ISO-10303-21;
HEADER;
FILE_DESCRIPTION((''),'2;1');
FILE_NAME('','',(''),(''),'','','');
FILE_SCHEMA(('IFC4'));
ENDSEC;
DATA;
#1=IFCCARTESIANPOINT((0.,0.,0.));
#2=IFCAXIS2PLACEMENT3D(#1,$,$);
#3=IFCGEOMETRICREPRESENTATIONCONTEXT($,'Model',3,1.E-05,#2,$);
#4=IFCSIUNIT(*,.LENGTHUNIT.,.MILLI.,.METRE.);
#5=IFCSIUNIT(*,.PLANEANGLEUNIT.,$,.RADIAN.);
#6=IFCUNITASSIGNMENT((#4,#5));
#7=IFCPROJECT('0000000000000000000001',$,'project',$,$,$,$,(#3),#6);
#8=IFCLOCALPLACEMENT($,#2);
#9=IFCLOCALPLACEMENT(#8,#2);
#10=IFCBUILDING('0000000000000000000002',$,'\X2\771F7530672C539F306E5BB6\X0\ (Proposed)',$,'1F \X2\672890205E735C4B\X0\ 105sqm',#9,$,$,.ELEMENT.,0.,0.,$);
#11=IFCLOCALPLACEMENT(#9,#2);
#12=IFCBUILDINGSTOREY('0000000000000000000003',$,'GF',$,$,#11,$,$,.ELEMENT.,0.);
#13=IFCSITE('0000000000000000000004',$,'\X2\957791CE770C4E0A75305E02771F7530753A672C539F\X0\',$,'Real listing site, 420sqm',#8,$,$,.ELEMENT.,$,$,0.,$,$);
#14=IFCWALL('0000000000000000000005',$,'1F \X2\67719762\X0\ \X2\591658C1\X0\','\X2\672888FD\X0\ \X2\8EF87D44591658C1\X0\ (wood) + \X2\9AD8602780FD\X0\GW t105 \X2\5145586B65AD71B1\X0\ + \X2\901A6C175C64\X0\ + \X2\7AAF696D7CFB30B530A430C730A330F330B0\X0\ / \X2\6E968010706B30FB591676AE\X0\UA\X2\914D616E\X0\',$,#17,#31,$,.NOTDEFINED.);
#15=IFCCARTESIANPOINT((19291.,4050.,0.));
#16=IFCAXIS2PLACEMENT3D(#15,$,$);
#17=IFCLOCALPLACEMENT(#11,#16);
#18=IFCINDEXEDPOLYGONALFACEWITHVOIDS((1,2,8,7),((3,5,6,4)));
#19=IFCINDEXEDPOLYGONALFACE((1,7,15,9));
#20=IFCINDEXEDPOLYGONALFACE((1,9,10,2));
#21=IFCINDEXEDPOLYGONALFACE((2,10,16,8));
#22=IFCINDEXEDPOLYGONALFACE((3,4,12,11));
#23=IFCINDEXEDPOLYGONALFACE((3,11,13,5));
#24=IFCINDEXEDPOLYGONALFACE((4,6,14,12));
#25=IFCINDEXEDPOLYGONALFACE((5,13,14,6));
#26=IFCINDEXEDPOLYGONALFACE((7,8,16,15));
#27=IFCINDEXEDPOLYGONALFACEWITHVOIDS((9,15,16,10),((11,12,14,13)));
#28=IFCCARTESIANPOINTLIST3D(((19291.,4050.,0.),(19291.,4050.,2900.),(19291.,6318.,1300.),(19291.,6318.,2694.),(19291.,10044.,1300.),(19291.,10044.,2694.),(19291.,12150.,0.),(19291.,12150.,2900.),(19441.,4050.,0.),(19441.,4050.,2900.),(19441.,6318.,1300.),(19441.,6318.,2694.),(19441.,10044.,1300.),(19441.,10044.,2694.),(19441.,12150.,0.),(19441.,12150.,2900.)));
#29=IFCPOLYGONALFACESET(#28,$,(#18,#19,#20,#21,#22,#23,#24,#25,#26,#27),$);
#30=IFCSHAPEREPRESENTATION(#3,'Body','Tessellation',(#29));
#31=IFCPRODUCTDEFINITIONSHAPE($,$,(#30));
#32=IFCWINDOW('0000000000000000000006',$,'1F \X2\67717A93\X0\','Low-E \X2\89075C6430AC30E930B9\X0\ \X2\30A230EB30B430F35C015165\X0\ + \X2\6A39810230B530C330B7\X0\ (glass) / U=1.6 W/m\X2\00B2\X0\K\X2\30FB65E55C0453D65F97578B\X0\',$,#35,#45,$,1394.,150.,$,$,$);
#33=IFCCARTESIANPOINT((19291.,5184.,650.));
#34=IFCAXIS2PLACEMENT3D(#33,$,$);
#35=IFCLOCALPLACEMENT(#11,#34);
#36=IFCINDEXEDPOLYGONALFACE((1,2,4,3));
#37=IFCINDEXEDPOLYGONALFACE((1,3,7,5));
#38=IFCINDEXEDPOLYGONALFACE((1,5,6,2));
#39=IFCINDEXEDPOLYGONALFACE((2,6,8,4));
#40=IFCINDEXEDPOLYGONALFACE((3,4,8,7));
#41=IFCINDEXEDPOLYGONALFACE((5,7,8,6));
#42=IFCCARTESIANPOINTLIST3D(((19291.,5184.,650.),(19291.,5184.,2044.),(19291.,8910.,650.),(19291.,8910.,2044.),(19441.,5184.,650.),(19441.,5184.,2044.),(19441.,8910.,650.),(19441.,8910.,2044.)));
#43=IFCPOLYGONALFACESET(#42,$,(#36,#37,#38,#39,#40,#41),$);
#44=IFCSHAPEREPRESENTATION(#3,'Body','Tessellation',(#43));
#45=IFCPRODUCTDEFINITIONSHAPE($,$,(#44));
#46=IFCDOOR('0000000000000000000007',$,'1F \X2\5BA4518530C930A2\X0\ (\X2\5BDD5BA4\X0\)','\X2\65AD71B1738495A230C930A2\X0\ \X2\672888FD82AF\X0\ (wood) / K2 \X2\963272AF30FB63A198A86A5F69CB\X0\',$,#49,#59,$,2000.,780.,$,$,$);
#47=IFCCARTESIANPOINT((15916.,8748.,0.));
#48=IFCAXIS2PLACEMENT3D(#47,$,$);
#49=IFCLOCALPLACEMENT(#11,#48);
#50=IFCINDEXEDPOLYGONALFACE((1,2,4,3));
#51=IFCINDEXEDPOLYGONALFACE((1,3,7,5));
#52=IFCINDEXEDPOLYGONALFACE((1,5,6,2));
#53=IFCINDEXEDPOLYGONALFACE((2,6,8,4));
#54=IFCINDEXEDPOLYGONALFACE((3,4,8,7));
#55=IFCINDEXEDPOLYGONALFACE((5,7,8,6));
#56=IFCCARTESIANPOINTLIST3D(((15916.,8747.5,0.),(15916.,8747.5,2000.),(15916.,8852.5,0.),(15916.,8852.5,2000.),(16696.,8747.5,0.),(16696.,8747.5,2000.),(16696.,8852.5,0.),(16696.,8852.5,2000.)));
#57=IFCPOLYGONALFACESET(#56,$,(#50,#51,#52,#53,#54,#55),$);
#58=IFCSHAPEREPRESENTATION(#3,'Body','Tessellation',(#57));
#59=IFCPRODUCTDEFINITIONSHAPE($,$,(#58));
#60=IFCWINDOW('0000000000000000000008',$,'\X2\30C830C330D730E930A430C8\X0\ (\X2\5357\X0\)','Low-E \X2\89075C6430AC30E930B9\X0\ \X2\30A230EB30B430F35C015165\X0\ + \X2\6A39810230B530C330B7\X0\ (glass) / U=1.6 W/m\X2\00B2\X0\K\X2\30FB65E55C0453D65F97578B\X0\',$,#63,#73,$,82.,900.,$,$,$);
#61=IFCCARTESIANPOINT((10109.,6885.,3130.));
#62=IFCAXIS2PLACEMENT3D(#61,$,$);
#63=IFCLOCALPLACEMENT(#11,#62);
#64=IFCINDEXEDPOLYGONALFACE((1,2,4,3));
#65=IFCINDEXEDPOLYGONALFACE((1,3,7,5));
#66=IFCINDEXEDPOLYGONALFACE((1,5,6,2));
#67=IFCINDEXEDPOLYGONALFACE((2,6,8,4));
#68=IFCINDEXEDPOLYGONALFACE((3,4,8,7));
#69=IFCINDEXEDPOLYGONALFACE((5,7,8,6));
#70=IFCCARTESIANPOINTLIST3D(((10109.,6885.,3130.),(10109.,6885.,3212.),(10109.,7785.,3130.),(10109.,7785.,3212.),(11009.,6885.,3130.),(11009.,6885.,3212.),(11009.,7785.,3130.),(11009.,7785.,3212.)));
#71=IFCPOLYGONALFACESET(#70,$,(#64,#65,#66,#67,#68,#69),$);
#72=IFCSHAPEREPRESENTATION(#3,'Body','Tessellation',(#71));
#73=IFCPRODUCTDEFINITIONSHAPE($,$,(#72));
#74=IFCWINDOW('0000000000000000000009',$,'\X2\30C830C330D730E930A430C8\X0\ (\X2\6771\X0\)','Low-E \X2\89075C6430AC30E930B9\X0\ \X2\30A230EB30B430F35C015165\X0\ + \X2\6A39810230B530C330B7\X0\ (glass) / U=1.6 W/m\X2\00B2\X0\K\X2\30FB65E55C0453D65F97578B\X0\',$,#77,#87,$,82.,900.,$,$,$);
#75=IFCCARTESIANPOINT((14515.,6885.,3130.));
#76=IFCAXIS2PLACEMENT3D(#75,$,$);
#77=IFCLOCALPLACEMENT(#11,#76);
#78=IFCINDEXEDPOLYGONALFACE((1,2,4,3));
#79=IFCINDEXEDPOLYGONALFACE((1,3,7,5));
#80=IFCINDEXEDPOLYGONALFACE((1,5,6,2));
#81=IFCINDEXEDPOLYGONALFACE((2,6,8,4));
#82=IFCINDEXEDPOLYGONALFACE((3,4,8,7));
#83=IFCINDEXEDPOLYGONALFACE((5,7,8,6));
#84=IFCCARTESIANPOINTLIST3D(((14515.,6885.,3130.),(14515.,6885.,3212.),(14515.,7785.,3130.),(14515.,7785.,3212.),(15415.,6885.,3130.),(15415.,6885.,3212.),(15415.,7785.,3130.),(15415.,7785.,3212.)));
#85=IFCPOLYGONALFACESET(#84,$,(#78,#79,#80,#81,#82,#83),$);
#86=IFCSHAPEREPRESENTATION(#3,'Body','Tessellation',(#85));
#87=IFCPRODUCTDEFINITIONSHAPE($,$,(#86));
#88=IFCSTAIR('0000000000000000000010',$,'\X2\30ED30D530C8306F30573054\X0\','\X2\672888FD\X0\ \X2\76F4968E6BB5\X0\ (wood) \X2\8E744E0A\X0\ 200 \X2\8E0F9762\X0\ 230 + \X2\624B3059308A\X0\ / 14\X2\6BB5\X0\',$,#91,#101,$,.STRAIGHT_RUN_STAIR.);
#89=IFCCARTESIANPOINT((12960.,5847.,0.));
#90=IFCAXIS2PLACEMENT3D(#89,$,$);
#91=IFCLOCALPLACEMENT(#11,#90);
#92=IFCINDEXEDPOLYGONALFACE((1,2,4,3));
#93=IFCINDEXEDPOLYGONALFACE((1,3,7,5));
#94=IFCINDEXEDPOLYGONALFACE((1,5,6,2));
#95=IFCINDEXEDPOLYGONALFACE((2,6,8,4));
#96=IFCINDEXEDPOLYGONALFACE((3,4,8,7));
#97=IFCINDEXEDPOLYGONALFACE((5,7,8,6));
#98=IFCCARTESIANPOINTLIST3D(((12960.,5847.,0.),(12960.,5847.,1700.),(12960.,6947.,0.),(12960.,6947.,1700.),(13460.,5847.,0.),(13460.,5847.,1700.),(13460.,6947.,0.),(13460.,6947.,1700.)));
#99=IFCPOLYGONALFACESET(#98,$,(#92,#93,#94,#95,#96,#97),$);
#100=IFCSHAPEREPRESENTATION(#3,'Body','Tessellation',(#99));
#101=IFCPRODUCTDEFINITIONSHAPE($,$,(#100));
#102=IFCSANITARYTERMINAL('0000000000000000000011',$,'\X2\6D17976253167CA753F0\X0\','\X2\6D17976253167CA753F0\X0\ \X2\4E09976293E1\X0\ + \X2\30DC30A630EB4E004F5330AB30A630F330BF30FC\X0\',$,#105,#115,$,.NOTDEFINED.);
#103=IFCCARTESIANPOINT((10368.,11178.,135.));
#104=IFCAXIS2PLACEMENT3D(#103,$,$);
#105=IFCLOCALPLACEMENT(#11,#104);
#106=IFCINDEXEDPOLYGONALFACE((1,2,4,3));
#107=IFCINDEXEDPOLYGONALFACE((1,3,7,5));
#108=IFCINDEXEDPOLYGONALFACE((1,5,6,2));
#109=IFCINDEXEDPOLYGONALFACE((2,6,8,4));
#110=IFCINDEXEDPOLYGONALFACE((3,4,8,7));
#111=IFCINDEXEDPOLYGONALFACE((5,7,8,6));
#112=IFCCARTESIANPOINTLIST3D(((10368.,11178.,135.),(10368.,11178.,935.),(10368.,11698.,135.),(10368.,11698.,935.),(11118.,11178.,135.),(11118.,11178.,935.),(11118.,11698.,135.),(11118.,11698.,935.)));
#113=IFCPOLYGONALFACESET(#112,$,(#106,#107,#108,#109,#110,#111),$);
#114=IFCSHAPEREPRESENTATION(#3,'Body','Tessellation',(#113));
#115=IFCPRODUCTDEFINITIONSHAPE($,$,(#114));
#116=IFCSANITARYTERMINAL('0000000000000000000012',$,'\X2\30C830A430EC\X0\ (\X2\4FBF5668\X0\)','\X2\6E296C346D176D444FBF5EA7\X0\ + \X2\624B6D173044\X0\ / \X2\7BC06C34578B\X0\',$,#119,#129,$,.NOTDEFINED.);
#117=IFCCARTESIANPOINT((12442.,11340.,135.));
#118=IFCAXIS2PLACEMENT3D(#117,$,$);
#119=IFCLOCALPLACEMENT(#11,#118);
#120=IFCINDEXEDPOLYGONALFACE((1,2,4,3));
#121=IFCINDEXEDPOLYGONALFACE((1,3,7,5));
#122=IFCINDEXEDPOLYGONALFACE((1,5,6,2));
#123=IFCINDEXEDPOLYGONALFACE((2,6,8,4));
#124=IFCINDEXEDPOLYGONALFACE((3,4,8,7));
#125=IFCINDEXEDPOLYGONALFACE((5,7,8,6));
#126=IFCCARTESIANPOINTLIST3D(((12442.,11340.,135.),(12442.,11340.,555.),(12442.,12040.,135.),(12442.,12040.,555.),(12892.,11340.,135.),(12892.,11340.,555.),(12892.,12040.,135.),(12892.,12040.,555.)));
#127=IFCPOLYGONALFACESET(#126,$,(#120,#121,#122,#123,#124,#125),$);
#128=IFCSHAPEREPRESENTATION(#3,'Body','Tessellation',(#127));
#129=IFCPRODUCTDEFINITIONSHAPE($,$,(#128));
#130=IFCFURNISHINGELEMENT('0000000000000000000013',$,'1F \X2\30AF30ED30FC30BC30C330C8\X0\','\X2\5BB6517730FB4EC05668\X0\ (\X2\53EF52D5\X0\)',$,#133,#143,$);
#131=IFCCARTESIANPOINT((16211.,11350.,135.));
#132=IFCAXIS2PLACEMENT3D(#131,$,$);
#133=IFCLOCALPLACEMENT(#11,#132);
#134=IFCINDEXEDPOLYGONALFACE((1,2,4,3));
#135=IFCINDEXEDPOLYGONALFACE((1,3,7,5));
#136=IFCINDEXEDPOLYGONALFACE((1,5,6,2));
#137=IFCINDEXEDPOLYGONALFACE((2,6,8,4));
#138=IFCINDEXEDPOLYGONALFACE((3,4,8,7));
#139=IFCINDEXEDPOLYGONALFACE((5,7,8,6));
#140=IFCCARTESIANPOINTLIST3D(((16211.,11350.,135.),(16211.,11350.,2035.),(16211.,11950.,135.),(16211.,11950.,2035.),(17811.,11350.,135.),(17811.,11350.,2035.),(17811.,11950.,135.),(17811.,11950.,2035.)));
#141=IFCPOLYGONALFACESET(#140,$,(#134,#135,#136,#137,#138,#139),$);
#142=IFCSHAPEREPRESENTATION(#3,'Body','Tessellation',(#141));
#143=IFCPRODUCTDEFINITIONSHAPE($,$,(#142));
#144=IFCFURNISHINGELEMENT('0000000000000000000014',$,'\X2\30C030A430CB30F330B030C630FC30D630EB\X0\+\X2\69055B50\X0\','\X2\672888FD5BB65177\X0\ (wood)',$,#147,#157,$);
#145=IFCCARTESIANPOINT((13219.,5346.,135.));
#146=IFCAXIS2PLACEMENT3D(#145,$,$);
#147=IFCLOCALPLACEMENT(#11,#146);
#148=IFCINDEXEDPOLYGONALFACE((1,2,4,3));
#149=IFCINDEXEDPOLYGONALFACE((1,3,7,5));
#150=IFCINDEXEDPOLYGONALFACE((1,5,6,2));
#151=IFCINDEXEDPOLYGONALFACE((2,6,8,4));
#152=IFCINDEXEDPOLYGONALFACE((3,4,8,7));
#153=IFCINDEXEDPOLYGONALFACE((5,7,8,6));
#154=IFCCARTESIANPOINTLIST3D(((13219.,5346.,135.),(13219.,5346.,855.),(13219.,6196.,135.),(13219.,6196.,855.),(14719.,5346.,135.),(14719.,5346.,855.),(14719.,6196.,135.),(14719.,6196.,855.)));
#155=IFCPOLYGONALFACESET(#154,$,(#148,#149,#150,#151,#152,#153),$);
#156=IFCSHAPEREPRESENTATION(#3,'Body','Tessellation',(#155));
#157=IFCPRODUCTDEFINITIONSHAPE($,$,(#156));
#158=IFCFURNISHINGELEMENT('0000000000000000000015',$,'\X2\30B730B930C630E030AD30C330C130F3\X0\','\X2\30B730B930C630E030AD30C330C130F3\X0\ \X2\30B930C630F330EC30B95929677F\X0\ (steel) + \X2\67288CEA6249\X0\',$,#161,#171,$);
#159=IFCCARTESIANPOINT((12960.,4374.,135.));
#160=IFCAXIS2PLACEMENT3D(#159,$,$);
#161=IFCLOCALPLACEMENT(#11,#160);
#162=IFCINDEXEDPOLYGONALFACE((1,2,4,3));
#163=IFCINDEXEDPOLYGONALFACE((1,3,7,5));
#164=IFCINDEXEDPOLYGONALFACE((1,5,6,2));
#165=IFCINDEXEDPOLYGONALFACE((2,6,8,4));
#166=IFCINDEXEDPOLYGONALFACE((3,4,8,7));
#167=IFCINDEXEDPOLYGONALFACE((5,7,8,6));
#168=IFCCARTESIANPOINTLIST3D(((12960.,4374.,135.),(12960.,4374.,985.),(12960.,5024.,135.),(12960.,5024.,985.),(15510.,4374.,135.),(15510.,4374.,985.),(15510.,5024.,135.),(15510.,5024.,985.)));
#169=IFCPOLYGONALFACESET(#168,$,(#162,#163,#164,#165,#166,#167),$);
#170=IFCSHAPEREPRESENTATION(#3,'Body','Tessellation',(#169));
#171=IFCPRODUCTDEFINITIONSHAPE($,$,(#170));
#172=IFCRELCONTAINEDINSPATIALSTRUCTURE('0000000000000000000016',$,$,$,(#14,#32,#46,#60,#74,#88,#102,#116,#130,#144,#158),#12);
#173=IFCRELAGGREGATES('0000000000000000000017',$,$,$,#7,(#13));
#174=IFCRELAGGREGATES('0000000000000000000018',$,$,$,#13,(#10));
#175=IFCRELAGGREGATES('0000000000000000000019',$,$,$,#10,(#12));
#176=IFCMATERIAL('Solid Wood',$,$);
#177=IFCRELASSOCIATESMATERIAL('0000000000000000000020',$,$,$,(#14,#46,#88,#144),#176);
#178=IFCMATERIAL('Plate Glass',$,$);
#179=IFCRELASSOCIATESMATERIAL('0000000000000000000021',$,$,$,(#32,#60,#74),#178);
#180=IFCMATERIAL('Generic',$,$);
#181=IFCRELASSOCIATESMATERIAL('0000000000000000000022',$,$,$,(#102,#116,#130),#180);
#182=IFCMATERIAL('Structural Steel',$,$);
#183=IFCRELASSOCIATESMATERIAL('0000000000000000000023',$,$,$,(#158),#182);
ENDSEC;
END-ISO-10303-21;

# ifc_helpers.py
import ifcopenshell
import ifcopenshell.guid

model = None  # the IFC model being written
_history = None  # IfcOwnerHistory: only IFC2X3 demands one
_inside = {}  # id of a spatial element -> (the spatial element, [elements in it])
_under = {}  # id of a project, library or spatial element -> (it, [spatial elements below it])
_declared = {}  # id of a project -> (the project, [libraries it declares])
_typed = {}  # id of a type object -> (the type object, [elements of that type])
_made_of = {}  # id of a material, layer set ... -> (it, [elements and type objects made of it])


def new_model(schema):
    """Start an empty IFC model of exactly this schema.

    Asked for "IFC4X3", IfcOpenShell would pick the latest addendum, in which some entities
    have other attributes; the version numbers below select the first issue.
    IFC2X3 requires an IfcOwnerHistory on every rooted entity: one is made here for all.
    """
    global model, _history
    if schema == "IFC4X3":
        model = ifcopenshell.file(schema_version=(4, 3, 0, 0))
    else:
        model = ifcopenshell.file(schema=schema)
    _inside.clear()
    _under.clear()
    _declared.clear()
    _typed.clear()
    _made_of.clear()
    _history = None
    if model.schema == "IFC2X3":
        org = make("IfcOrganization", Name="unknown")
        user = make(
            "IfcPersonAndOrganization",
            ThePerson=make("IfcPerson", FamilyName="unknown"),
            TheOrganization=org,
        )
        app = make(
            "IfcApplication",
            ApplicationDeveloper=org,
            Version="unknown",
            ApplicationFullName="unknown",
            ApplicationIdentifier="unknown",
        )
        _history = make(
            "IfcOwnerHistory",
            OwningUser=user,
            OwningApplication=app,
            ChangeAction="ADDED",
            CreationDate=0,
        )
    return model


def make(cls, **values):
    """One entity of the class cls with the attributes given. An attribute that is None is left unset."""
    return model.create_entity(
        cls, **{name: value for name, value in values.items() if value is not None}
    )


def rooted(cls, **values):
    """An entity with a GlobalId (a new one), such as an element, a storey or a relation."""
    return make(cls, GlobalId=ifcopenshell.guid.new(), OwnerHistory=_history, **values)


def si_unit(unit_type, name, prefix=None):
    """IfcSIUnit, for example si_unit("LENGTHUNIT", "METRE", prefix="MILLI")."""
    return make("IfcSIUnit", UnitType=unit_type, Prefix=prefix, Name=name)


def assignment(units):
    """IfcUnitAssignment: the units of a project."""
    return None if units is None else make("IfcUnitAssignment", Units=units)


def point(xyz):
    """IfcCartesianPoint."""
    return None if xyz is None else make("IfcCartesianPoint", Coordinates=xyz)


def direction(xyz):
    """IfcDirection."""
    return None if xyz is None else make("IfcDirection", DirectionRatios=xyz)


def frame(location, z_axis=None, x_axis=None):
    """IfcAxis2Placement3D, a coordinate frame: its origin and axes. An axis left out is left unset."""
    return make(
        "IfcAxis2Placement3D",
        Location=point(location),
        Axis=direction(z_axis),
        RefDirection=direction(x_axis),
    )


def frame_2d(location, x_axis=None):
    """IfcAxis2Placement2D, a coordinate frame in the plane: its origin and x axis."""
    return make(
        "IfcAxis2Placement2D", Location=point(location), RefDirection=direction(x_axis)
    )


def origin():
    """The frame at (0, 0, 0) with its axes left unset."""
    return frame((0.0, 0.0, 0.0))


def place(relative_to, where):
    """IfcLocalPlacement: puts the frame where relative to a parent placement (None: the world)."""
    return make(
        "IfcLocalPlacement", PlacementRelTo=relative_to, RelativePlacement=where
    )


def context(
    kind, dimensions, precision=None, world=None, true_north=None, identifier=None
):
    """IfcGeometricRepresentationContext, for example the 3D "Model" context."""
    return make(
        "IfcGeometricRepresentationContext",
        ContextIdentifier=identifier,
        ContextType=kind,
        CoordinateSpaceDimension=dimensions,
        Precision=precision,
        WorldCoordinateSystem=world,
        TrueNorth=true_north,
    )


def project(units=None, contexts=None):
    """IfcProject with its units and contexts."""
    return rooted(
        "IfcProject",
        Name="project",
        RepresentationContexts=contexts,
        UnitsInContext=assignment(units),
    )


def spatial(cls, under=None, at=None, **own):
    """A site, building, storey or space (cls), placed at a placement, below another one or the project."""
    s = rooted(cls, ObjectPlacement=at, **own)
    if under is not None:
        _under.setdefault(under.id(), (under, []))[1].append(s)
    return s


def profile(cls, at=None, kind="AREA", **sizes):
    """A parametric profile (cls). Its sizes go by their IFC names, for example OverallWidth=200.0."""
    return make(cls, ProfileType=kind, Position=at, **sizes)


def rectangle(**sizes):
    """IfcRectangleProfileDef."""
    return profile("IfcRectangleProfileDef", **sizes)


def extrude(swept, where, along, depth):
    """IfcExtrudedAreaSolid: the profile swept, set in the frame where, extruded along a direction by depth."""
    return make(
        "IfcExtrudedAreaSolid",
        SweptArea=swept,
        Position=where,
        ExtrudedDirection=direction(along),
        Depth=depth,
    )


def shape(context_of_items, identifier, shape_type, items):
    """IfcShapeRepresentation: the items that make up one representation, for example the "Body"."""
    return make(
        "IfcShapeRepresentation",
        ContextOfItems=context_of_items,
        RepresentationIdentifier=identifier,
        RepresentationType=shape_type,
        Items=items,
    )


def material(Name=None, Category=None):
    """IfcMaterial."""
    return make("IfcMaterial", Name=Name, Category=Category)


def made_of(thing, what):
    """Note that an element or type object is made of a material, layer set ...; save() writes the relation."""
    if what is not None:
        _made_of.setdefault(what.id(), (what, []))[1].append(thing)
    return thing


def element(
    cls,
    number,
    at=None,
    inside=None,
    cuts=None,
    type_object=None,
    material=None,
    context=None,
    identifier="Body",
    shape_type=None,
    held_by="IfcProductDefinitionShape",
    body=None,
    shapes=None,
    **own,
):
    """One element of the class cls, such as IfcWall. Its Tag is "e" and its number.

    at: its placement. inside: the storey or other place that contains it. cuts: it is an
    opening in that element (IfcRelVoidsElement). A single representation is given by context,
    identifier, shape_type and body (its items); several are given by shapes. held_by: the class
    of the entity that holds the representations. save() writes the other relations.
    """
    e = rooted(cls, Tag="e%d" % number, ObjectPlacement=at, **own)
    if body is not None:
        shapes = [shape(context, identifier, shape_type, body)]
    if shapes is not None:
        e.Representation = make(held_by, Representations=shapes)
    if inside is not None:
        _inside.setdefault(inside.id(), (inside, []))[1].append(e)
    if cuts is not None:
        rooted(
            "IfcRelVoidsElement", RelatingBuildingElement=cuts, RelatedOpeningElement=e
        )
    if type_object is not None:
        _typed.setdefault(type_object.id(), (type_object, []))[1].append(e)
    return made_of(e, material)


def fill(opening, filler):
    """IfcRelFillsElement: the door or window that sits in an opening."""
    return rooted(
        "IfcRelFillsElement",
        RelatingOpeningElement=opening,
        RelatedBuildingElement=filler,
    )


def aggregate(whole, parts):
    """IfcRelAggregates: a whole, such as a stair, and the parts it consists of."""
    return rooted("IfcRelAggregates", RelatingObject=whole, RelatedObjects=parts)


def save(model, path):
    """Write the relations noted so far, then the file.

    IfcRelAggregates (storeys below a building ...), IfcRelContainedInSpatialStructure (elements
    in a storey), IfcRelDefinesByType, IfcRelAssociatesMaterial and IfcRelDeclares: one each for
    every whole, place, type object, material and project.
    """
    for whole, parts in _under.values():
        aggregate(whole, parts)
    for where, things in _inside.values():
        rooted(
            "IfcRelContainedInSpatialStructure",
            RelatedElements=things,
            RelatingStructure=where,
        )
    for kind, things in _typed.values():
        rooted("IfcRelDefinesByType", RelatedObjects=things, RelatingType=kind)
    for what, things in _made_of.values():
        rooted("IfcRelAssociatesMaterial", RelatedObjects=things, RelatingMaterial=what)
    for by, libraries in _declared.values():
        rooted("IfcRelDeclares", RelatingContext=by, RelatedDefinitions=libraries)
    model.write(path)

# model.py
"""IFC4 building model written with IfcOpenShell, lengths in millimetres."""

from ifc_helpers import new_model, si_unit, frame, frame_2d, origin, place, context, project, spatial, rectangle, extrude, material, element, fill, save


model = new_model("IFC4")

# Units and contexts
model_context = context("Model", 3, precision=1e-05, world=origin())
ifc_project = project(units=[si_unit("LENGTHUNIT", "METRE", prefix="MILLI"), si_unit("PLANEANGLEUNIT", "RADIAN")], contexts=[model_context])

# Site, building, storey
site_placement = place(None, origin())
site = spatial("IfcSite", under=ifc_project, at=site_placement, Name="長野県上田市真田町本原", ObjectType="Real listing site, 420sqm", CompositionType="ELEMENT", RefElevation=0.0)
building_placement = place(site_placement, origin())
building = spatial("IfcBuilding", under=site, at=building_placement, Name="真田本原の家 (Proposed)", ObjectType="1F 木造平屋 105sqm", CompositionType="ELEMENT", ElevationOfRefHeight=0.0, ElevationOfTerrain=0.0)
storey_placement = place(building_placement, origin())
storey = spatial("IfcBuildingStorey", under=building, at=storey_placement, Name="GF", CompositionType="ELEMENT", Elevation=0.0)

# Wall, opening, window
ifc_material_1 = material(Name="Solid Wood")
wall_1_placement = place(storey_placement, frame((19291.0, 4050.0, 0.0)))
wall_1 = element("IfcWall", 1, at=wall_1_placement, inside=storey, material=ifc_material_1, Name="1F 東面 外壁", Description="木製 軸組外壁 (wood) + 高性能GW t105 充填断熱 + 通気層 + 窯業系サイディング / 準耐火・外皮UA配慮", PredefinedType="NOTDEFINED", context=model_context, shape_type="SweptSolid", body=[
    extrude(rectangle(XDim=150.0, YDim=8100.0, at=frame_2d((75.0, 4050.0))), frame((19291.0, 4050.0, 0.0)), (0.0, 0.0, 1.0), 2900.0),
])
opening_placement = place(storey_placement, frame((19291.0, 5184.0, 650.0)))
opening = element("IfcOpeningElement", 2, at=opening_placement, cuts=wall_1, PredefinedType="NOTDEFINED", context=model_context, shape_type="SweptSolid", body=[
    extrude(rectangle(XDim=150.0, YDim=3726.0, at=frame_2d((75.0, 1863.0))), frame((19291.0, 5184.0, 650.0)), (0.0, 0.0, 1.0), 1394.0),
])
ifc_material_2 = material(Name="Plate Glass")
window_1_placement = place(storey_placement, frame((19291.0, 5184.0, 650.0)))
window_1 = element("IfcWindow", 3, at=window_1_placement, inside=storey, material=ifc_material_2, Name="1F 東窓", Description="Low-E 複層ガラス アルゴン封入 + 樹脂サッシ (glass) / U=1.6 W/m²K・日射取得型", OverallHeight=1394.0, OverallWidth=150.0, context=model_context, shape_type="SweptSolid", body=[
    extrude(rectangle(XDim=150.0, YDim=3726.0, at=frame_2d((75.0, 1863.0))), frame((19291.0, 5184.0, 650.0)), (0.0, 0.0, 1.0), 1394.0),
])
fill(opening, window_1)

# Door
door_placement = place(storey_placement, frame((15916.0, 8748.0, 0.0)))
element("IfcDoor", 4, at=door_placement, inside=storey, material=ifc_material_1, Name="1F 室内ドア (寝室)", Description="断熱玄関ドア 木製芯 (wood) / K2 防犯・採風機構", OverallHeight=2000.0, OverallWidth=780.0, context=model_context, shape_type="SweptSolid", body=[
    extrude(rectangle(XDim=780.0, YDim=105.0, at=frame_2d((390.0, 52.0))), frame((15916.0, 8748.0, 0.0)), (0.0, 0.0, 1.0), 2000.0),
])

# Windows
window_2_placement = place(storey_placement, frame((10109.0, 6885.0, 3130.0)))
element("IfcWindow", 5, at=window_2_placement, inside=storey, material=ifc_material_2, Name="トップライト (南)", Description="Low-E 複層ガラス アルゴン封入 + 樹脂サッシ (glass) / U=1.6 W/m²K・日射取得型", OverallHeight=82.0, OverallWidth=900.0, context=model_context, shape_type="SweptSolid", body=[
    extrude(rectangle(XDim=900.0, YDim=900.0, at=frame_2d((450.0, 450.0))), frame((10109.0, 6885.0, 3130.0)), (0.0, 0.0, 1.0), 82.0),
])
window_3_placement = place(storey_placement, frame((14515.0, 6885.0, 3130.0)))
element("IfcWindow", 6, at=window_3_placement, inside=storey, material=ifc_material_2, Name="トップライト (東)", Description="Low-E 複層ガラス アルゴン封入 + 樹脂サッシ (glass) / U=1.6 W/m²K・日射取得型", OverallHeight=82.0, OverallWidth=900.0, context=model_context, shape_type="SweptSolid", body=[
    extrude(rectangle(XDim=900.0, YDim=900.0, at=frame_2d((450.0, 450.0))), frame((14515.0, 6885.0, 3130.0)), (0.0, 0.0, 1.0), 82.0),
])

# Stair
stair_placement = place(storey_placement, frame((12960.0, 5847.0, 0.0)))
element("IfcStair", 7, at=stair_placement, inside=storey, material=ifc_material_1, Name="ロフトはしご", Description="木製 直階段 (wood) 蹴上 200 踏面 230 + 手すり / 14段", PredefinedType="STRAIGHT_RUN_STAIR", context=model_context, shape_type="SweptSolid", body=[
    extrude(rectangle(XDim=500.0, YDim=1100.0, at=frame_2d((250.0, 550.0))), frame((12960.0, 5847.0, 0.0)), (0.0, 0.0, 1.0), 1700.0),
])

# Sanitary terminals
ifc_material_3 = material(Name="Generic")
sanitary_terminal_1_placement = place(storey_placement, frame((10368.0, 11178.0, 135.0)))
element("IfcSanitaryTerminal", 8, at=sanitary_terminal_1_placement, inside=storey, material=ifc_material_3, Name="洗面化粧台", Description="洗面化粧台 三面鏡 + ボウル一体カウンター", PredefinedType="NOTDEFINED", context=model_context, shape_type="SweptSolid", body=[
    extrude(rectangle(XDim=750.0, YDim=520.0, at=frame_2d((375.0, 260.0))), frame((10368.0, 11178.0, 135.0)), (0.0, 0.0, 1.0), 800.0),
])
sanitary_terminal_2_placement = place(storey_placement, frame((12442.0, 11340.0, 135.0)))
element("IfcSanitaryTerminal", 9, at=sanitary_terminal_2_placement, inside=storey, material=ifc_material_3, Name="トイレ (便器)", Description="温水洗浄便座 + 手洗い / 節水型", PredefinedType="NOTDEFINED", context=model_context, shape_type="SweptSolid", body=[
    extrude(rectangle(XDim=450.0, YDim=700.0, at=frame_2d((225.0, 350.0))), frame((12442.0, 11340.0, 135.0)), (0.0, 0.0, 1.0), 420.0),
])

# Furnishing elements
furnishing_1_placement = place(storey_placement, frame((16211.0, 11350.0, 135.0)))
element("IfcFurnishingElement", 10, at=furnishing_1_placement, inside=storey, material=ifc_material_3, Name="1F クローゼット", Description="家具・什器 (可動)", context=model_context, shape_type="SweptSolid", body=[
    extrude(rectangle(XDim=1600.0, YDim=600.0, at=frame_2d((800.0, 300.0))), frame((16211.0, 11350.0, 135.0)), (0.0, 0.0, 1.0), 1900.0),
])
furnishing_2_placement = place(storey_placement, frame((13219.0, 5346.0, 135.0)))
element("IfcFurnishingElement", 11, at=furnishing_2_placement, inside=storey, material=ifc_material_1, Name="ダイニングテーブル+椅子", Description="木製家具 (wood)", context=model_context, shape_type="SweptSolid", body=[
    extrude(rectangle(XDim=1500.0, YDim=850.0, at=frame_2d((750.0, 425.0))), frame((13219.0, 5346.0, 135.0)), (0.0, 0.0, 1.0), 720.0),
])
ifc_material_4 = material(Name="Structural Steel")
furnishing_3_placement = place(storey_placement, frame((12960.0, 4374.0, 135.0)))
element("IfcFurnishingElement", 12, at=furnishing_3_placement, inside=storey, material=ifc_material_4, Name="システムキッチン", Description="システムキッチン ステンレス天板 (steel) + 木質扉", context=model_context, shape_type="SweptSolid", body=[
    extrude(rectangle(XDim=2550.0, YDim=650.0, at=frame_2d((1275.0, 325.0))), frame((12960.0, 4374.0, 135.0)), (0.0, 0.0, 1.0), 850.0),
])

save(model, "model.ifc")
